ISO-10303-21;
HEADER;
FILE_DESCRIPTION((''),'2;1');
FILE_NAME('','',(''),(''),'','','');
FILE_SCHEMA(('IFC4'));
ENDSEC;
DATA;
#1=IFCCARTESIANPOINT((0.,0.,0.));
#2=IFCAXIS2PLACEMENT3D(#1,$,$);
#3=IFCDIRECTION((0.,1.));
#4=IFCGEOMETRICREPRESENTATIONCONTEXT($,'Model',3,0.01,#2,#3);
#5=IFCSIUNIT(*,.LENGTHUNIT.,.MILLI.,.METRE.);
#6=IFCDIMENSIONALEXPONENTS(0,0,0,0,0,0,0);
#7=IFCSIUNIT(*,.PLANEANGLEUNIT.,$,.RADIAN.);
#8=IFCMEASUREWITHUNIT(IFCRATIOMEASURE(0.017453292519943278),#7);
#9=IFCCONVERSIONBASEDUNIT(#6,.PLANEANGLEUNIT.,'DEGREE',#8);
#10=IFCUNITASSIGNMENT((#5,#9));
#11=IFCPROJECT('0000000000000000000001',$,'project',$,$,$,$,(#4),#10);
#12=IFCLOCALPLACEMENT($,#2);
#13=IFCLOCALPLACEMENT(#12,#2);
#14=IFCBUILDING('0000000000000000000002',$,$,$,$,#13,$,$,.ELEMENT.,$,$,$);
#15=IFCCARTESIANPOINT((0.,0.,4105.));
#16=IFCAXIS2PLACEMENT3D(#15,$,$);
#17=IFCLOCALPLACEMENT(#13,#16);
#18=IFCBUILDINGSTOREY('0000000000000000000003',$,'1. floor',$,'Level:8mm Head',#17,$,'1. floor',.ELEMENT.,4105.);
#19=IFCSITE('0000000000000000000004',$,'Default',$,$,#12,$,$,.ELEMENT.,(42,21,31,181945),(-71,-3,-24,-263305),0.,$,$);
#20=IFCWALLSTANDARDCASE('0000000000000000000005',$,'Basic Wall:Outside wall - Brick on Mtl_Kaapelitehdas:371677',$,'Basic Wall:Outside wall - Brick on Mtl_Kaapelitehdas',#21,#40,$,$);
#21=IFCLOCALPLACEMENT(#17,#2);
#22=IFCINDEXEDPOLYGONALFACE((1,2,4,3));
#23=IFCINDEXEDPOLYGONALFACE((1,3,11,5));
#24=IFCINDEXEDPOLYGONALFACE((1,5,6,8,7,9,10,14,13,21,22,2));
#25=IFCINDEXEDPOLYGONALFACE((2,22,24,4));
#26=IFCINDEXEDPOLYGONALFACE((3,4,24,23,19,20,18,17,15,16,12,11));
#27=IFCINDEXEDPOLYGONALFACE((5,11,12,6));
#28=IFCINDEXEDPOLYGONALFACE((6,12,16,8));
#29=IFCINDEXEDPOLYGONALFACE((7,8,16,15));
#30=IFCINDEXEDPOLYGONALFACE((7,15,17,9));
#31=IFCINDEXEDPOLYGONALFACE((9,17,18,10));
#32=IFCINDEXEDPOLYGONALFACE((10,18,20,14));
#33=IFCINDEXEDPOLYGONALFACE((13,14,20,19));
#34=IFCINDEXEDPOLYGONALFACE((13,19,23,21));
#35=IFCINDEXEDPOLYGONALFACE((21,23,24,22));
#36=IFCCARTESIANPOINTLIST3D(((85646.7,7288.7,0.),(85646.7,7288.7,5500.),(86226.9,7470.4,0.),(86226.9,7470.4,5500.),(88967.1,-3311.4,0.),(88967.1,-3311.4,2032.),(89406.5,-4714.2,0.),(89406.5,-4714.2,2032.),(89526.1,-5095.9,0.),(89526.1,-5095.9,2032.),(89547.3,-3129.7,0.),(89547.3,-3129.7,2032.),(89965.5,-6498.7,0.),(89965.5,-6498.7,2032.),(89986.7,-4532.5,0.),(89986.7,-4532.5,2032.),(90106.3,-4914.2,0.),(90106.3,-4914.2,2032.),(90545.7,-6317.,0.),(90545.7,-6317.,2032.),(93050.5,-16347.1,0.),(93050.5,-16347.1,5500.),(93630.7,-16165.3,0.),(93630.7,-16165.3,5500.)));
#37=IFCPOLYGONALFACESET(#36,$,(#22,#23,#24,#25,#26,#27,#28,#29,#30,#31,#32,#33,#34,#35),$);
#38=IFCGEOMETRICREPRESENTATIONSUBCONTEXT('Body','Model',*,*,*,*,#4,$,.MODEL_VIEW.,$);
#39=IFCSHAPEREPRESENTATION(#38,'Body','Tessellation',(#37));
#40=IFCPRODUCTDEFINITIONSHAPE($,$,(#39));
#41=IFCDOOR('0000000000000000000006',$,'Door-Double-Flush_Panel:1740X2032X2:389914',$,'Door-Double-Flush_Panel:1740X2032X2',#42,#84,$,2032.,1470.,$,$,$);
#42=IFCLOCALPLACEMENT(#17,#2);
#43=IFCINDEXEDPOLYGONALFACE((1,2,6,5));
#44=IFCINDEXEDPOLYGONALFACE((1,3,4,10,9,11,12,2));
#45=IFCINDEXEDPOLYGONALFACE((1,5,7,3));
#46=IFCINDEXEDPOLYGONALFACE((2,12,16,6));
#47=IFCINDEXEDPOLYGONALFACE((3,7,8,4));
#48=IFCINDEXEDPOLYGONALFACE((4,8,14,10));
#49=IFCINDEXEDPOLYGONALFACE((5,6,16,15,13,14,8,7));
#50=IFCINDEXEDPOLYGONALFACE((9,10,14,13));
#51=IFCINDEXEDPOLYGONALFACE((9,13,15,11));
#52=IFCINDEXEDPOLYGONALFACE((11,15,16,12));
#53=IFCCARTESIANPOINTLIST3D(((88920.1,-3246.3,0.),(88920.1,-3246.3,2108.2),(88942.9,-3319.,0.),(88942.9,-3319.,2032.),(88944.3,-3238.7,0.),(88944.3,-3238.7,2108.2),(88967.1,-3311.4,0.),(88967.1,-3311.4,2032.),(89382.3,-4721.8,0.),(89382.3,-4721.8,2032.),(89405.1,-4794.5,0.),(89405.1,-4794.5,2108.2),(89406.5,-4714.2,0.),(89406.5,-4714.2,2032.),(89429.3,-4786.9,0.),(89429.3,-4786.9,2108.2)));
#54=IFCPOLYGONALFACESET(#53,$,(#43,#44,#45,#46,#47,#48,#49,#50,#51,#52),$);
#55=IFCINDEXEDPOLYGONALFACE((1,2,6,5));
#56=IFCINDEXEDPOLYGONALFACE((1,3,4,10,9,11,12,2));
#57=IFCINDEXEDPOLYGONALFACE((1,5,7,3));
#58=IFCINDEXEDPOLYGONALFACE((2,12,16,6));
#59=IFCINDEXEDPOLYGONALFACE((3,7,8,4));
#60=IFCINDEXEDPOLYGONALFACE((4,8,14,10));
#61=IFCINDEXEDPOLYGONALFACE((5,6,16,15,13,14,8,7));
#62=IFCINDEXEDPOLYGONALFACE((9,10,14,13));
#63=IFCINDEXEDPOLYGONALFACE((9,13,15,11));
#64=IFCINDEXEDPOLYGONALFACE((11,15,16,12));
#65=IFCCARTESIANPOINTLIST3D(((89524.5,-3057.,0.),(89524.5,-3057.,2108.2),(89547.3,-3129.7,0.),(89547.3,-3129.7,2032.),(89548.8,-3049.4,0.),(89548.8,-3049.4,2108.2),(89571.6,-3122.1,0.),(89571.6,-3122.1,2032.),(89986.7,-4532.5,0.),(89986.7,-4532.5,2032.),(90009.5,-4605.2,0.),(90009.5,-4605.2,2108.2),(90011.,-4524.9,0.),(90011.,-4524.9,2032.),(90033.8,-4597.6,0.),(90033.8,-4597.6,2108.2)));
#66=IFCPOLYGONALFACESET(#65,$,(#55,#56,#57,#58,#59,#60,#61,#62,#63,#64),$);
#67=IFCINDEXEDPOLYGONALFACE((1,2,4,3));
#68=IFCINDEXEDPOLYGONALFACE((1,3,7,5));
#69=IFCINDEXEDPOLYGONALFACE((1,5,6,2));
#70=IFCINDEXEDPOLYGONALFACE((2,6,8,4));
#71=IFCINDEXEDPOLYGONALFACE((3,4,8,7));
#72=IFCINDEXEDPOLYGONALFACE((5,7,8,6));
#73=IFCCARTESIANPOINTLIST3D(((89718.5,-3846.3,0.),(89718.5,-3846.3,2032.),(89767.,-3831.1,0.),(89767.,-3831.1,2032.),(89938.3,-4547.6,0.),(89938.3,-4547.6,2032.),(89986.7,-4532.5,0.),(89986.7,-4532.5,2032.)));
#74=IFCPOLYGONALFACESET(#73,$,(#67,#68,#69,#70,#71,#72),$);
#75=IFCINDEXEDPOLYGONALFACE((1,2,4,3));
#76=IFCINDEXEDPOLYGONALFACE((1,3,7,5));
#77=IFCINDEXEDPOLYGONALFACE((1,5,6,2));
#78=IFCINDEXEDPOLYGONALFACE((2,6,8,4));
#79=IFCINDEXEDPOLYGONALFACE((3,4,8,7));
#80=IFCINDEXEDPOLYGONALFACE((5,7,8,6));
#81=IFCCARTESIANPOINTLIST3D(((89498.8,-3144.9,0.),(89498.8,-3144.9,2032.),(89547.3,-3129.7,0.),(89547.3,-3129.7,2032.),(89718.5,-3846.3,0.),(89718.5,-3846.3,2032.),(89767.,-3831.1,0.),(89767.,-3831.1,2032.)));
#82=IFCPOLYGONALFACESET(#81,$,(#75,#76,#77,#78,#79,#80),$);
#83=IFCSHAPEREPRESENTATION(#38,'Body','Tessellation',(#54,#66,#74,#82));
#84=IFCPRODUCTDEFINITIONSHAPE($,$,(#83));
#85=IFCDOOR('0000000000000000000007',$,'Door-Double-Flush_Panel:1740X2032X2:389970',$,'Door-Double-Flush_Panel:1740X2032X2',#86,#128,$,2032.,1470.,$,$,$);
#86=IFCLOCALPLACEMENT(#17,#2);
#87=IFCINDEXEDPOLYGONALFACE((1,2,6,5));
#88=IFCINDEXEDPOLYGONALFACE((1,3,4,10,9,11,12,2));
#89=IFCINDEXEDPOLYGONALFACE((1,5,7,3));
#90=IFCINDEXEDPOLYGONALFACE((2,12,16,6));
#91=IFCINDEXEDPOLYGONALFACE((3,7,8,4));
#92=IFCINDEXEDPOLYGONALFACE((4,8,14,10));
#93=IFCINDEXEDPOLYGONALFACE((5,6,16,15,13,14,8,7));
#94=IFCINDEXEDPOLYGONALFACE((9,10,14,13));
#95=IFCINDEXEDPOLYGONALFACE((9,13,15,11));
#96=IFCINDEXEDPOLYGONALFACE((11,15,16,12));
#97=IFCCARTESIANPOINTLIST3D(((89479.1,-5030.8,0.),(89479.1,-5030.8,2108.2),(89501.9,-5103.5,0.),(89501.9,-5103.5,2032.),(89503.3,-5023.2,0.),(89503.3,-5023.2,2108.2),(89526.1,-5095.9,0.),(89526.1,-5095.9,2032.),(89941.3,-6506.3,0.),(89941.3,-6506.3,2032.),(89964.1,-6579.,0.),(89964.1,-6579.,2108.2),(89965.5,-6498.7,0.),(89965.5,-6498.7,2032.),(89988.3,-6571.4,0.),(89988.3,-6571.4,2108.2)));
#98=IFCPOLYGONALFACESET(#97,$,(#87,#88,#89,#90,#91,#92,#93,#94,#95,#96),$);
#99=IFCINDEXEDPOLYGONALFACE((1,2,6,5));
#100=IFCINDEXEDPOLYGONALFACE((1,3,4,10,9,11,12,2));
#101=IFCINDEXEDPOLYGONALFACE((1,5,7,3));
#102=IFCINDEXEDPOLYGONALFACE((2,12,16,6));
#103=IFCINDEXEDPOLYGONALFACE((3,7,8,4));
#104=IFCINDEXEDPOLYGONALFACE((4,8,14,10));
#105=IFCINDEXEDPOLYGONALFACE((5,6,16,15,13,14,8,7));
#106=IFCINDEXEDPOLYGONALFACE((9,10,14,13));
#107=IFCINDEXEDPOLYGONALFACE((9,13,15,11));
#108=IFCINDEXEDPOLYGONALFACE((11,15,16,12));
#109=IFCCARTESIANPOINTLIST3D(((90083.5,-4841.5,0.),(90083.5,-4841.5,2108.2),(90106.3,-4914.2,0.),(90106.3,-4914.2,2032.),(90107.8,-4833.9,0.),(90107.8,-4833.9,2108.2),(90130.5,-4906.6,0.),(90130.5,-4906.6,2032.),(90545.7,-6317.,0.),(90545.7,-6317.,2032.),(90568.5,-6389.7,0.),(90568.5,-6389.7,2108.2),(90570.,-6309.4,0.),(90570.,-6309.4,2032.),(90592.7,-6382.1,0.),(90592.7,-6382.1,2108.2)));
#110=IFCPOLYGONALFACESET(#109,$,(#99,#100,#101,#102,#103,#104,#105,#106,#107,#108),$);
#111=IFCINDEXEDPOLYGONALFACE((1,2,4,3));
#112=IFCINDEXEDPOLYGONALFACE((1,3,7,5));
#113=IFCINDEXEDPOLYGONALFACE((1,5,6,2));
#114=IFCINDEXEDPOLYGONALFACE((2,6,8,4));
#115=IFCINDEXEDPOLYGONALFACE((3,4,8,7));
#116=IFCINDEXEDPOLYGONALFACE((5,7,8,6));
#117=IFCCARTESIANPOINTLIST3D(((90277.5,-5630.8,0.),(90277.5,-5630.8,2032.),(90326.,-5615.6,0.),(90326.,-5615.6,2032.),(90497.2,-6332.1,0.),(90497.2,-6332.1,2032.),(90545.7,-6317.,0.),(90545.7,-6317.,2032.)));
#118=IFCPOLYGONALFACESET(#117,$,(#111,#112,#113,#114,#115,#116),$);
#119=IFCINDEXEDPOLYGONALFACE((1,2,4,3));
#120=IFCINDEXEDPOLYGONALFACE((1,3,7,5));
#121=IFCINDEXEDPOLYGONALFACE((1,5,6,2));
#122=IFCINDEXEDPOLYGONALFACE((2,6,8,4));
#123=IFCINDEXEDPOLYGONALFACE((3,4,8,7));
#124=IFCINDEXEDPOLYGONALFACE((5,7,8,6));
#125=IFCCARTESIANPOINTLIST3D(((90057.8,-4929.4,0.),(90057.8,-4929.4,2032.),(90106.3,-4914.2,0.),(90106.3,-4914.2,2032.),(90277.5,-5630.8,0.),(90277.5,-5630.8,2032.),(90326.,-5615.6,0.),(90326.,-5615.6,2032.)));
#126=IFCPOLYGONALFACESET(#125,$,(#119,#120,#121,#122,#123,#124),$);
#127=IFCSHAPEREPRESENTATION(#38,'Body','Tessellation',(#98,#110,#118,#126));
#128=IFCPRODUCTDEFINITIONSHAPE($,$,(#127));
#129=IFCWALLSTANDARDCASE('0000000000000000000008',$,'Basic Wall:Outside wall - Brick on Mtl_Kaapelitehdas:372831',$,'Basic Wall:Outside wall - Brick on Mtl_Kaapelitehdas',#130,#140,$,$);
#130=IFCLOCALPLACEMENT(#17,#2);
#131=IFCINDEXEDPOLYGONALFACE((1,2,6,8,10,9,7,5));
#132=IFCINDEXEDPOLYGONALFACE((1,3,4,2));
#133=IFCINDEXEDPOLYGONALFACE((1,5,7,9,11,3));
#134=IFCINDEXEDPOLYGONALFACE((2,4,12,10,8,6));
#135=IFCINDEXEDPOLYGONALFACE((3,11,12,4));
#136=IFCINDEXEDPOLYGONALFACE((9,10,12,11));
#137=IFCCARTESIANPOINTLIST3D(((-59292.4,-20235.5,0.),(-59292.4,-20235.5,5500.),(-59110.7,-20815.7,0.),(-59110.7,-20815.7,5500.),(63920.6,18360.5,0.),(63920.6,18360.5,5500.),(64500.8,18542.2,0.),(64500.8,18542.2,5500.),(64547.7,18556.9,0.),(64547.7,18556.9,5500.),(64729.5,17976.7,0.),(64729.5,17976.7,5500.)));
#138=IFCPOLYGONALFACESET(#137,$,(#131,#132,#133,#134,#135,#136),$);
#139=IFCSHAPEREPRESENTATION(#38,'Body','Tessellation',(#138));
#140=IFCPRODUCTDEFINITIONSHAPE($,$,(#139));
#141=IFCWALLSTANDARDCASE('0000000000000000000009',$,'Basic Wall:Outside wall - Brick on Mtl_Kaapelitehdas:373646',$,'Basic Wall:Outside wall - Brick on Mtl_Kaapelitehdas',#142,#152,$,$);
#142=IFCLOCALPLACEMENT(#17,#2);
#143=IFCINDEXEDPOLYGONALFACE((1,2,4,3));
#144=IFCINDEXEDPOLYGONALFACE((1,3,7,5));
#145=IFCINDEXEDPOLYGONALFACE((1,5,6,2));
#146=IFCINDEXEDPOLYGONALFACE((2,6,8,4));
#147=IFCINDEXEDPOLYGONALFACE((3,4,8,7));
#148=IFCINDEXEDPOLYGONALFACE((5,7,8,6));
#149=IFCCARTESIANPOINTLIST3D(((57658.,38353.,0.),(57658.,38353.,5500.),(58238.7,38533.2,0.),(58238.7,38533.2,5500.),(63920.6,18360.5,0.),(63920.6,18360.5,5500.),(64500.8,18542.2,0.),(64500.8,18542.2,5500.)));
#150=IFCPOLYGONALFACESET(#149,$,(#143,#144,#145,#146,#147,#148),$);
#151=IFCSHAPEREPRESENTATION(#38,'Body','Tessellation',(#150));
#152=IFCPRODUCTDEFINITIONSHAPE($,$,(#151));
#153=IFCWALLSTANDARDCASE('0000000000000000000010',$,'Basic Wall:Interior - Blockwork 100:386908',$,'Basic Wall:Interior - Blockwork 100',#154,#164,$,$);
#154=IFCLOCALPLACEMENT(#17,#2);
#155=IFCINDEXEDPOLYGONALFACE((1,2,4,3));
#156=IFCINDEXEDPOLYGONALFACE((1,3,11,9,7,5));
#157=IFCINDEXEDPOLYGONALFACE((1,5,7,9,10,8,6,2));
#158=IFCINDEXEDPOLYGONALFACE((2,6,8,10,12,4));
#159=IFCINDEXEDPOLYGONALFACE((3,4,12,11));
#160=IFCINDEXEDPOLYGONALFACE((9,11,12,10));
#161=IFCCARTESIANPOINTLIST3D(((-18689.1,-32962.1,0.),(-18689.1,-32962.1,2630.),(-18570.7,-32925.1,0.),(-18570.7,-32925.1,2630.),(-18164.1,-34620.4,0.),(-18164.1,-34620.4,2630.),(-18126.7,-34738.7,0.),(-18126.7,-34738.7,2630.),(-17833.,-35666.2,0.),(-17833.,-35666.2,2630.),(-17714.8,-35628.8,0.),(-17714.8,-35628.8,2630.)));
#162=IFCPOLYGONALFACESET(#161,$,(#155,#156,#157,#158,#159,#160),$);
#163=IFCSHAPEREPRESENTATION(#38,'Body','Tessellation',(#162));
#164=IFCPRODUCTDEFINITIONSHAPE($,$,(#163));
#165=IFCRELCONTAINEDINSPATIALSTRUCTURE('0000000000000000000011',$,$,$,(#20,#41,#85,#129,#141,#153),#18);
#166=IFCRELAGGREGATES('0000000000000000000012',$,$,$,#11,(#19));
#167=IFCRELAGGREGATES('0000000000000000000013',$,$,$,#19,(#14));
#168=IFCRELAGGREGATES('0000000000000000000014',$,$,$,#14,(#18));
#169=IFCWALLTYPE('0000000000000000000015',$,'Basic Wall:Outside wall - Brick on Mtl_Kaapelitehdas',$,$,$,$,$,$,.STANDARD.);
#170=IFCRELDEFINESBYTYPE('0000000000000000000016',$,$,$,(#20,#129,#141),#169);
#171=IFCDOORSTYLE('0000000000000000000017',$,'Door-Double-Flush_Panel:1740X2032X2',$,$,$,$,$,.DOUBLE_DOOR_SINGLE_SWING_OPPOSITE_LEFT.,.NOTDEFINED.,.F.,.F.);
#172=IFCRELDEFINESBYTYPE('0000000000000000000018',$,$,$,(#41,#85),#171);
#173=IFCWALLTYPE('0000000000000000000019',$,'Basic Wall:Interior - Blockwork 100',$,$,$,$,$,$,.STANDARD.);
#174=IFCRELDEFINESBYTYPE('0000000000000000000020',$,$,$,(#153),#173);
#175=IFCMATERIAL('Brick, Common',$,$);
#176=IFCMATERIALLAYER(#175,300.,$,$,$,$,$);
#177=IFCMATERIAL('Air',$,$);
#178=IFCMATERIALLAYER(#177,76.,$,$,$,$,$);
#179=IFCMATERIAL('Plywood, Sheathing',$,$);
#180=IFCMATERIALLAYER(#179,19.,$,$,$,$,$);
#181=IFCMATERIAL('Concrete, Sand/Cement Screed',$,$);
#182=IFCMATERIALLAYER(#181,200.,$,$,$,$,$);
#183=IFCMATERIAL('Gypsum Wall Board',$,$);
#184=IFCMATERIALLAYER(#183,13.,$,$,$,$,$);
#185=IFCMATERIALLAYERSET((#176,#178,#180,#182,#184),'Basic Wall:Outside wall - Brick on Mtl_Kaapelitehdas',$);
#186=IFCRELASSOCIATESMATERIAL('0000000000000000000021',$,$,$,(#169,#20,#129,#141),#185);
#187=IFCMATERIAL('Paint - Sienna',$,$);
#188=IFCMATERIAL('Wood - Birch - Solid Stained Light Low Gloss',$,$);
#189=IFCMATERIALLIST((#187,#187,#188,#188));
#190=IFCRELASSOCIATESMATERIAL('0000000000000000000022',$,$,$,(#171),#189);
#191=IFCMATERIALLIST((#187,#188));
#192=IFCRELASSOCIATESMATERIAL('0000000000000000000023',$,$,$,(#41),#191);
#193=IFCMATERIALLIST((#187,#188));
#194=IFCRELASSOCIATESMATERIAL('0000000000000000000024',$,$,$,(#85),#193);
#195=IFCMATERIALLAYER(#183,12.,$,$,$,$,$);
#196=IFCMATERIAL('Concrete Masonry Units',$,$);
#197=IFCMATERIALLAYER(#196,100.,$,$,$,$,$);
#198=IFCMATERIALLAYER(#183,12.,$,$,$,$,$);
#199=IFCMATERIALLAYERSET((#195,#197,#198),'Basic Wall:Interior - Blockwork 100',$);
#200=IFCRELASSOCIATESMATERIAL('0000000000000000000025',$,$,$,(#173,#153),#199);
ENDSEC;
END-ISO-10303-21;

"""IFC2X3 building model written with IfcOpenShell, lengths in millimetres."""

from ifc_helpers import new_model, entity, si_unit, converted_unit, direction, frame, frame_2d, origin, origin_2d_with_axis, place, context, subcontext, project, spatial, polyline, rectangle, outline, extrude, source, transform, mapped, material, material_list, layer, layer_set, layer_usage, type_object, type_shapes, element, fill, save


model = new_model("IFC2X3")

# Units and contexts
model_context = context("Model", 3, precision=0.01, world=origin(), true_north=direction((0.0, 1.0)))
body_context = subcontext(model_context, "Body", "Model", "MODEL_VIEW")
ifc_project = project(units=[si_unit("LENGTHUNIT", "METRE", prefix="MILLI"), converted_unit("PLANEANGLEUNIT", "DEGREE", entity("IfcRatioMeasure", 0.017453292519943278), si_unit("PLANEANGLEUNIT", "RADIAN"), dimensions=[0, 0, 0, 0, 0, 0, 0])], contexts=[model_context])

# Site, building, storey
site_placement = place(None, origin())
site = spatial("IfcSite", under=ifc_project, at=site_placement, Name="Default", CompositionType="ELEMENT", RefLatitude=(42, 21, 31, 181945), RefLongitude=(-71, -3, -24, -263305), RefElevation=0.0)
building_placement = place(site_placement, origin())
building = spatial("IfcBuilding", under=site, at=building_placement, CompositionType="ELEMENT")
storey_placement = place(building_placement, frame((0.0, 0.0, 4105.0)))
storey = spatial("IfcBuildingStorey", under=building, at=storey_placement, Name="1. floor", ObjectType="Level:8mm Head", LongName="1. floor", CompositionType="ELEMENT", Elevation=4105.0)

# Wall, openings, doors
ifc_material_1 = material(Name="Brick, Common")
ifc_layer_1 = layer(ifc_material_1, 300.0)
ifc_material_2 = material(Name="Air")
ifc_layer_2 = layer(ifc_material_2, 76.0)
ifc_material_3 = material(Name="Plywood, Sheathing")
ifc_layer_3 = layer(ifc_material_3, 19.0)
ifc_material_4 = material(Name="Concrete, Sand/Cement Screed")
ifc_layer_4 = layer(ifc_material_4, 200.0)
ifc_material_5 = material(Name="Gypsum Wall Board")
ifc_layer_5 = layer(ifc_material_5, 13.0)
ifc_layer_set_1 = layer_set([ifc_layer_1, ifc_layer_2, ifc_layer_3, ifc_layer_4, ifc_layer_5], Name="Basic Wall:Outside wall - Brick on Mtl_Kaapelitehdas")
wall_type_1 = type_object("IfcWallType", Name="Basic Wall:Outside wall - Brick on Mtl_Kaapelitehdas", PredefinedType="STANDARD", material=ifc_layer_set_1)
ifc_material_6 = material(Name="Paint - Sienna")
ifc_material_7 = material(Name="Wood - Birch - Solid Stained Light Low Gloss")
ifc_material_list_1 = material_list([ifc_material_6, ifc_material_6, ifc_material_7, ifc_material_7])
door_style_1 = type_object("IfcDoorStyle", Name="Door-Double-Flush_Panel:1740X2032X2", ConstructionType="NOTDEFINED", OperationType="DOUBLE_DOOR_SINGLE_SWING_OPPOSITE_LEFT", ParameterTakesPrecedence=False, Sizeable=False, material=ifc_material_list_1)
shared_shape_1 = source(origin(), body_context, "Body", "SweptSolid", [
    extrude(outline(polyline([(-996.9, 735.0), (1035.0, 735.0), (1035.0, 811.2), (-1073.1, 811.2), (-1073.1, -811.2), (1035.0, -811.2), (1035.0, -735.0), (-996.9, -735.0), (-996.9, 735.0)])), frame((735.0, -25.4, 1035.0), z_axis=(0.0, 1.0, 0.0), x_axis=(0.0, 0.0, -1.0)), (0.0, 0.0, 1.0), 25.4),
    extrude(outline(polyline([(-996.9, 735.0), (1035.0, 735.0), (1035.0, 811.2), (-1073.1, 811.2), (-1073.1, -811.2), (1035.0, -811.2), (1035.0, -735.0), (-996.9, -735.0), (-996.9, 735.0)])), frame((735.0, 608.0, 1035.0), z_axis=(0.0, 1.0, 0.0), x_axis=(0.0, 0.0, -1.0)), (0.0, 0.0, 1.0), 25.4),
    extrude(rectangle(XDim=50.8, YDim=735.0, at=origin_2d_with_axis()), frame((1102.5, 582.6, 0.0), z_axis=(0.0, 0.0, 1.0), x_axis=(0.0, -1.0, 0.0)), (0.0, 0.0, 1.0), 2032.0),
    extrude(rectangle(XDim=50.8, YDim=735.0, at=frame_2d((0.0, 0.0), x_axis=(1.0, 0.0))), frame((367.5, 582.6, 0.0), z_axis=(0.0, 0.0, 1.0), x_axis=(0.0, -1.0, 0.0)), (0.0, 0.0, 1.0), 2032.0),
])
type_shapes(door_style_1, [shared_shape_1])
ifc_layer_usage_1 = layer_usage(ifc_layer_set_1, "AXIS2", "NEGATIVE", 304.0)
wall_1_placement = place(storey_placement, frame((85936.8, 7379.6, 0.0), z_axis=(0.0, 0.0, 1.0), x_axis=(0.298924, -0.954277, 0.0)))
wall_1 = element("IfcWallStandardCase", 1, at=wall_1_placement, inside=storey, type_object=wall_type_1, material=ifc_layer_usage_1, Name="Basic Wall:Outside wall - Brick on Mtl_Kaapelitehdas:371677", ObjectType="Basic Wall:Outside wall - Brick on Mtl_Kaapelitehdas", context=body_context, shape_type="SweptSolid", body=[
    extrude(rectangle(XDim=24768.2, YDim=608.0, at=frame_2d((12384.1, 0.0), x_axis=(-1.0, 0.0))), origin(), (0.0, 0.0, 1.0), 5500.0),
])
opening_1_placement = place(wall_1_placement, frame((11108.0, -304.0, 0.0)))
opening_1 = element("IfcOpeningElement", 2, at=opening_1_placement, cuts=wall_1, ObjectType="Opening", context=body_context, shape_type="SweptSolid", body=[
    extrude(rectangle(XDim=2032.0, YDim=1470.0, at=frame_2d((1016.0, 735.0), x_axis=(1.0, 0.0))), frame((0.0, 0.0, 0.0), z_axis=(0.0, 1.0, 0.0), x_axis=(0.0, 0.0, 1.0)), (0.0, 0.0, 1.0), 608.0),
])
opening_2_placement = place(wall_1_placement, frame((12978.0, -304.0, 0.0)))
opening_2 = element("IfcOpeningElement", 3, at=opening_2_placement, cuts=wall_1, ObjectType="Opening", context=body_context, shape_type="SweptSolid", body=[
    extrude(rectangle(XDim=2032.0, YDim=1470.0, at=frame_2d((1016.0, 735.0), x_axis=(1.0, 0.0))), frame((0.0, 0.0, 0.0), z_axis=(0.0, 1.0, 0.0), x_axis=(0.0, 0.0, 1.0)), (0.0, 0.0, 1.0), 608.0),
])
ifc_material_list_2 = material_list([ifc_material_6, ifc_material_7])
door_1_placement = place(opening_1_placement, origin())
door_1 = element("IfcDoor", 4, at=door_1_placement, inside=storey, type_object=door_style_1, material=ifc_material_list_2, Name="Door-Double-Flush_Panel:1740X2032X2:389914", ObjectType="Door-Double-Flush_Panel:1740X2032X2", OverallHeight=2032.0, OverallWidth=1470.0, context=body_context, shape_type="MappedRepresentation", body=[
    mapped(shared_shape_1, transform((0.0, 0.0, 0.0), scale=1.0)),
])
fill(opening_1, door_1)
ifc_material_list_3 = material_list([ifc_material_6, ifc_material_7])
door_2_placement = place(opening_2_placement, origin())
door_2 = element("IfcDoor", 5, at=door_2_placement, inside=storey, type_object=door_style_1, material=ifc_material_list_3, Name="Door-Double-Flush_Panel:1740X2032X2:389970", ObjectType="Door-Double-Flush_Panel:1740X2032X2", OverallHeight=2032.0, OverallWidth=1470.0, context=body_context, shape_type="MappedRepresentation", body=[
    mapped(shared_shape_1, transform((0.0, 0.0, 0.0), scale=1.0)),
])
fill(opening_2, door_2)

# Walls
ifc_layer_usage_2 = layer_usage(ifc_layer_set_1, "AXIS2", "NEGATIVE", 304.0)
wall_2_placement = place(storey_placement, frame((64638.6, 18266.8, 0.0), z_axis=(0.0, 0.0, 1.0), x_axis=(-0.954277, -0.298924, 0.0)))
element("IfcWallStandardCase", 6, at=wall_2_placement, inside=storey, type_object=wall_type_1, material=ifc_layer_usage_2, Name="Basic Wall:Outside wall - Brick on Mtl_Kaapelitehdas:372831", ObjectType="Basic Wall:Outside wall - Brick on Mtl_Kaapelitehdas", context=body_context, shape_type="SweptSolid", body=[
    extrude(outline(polyline([(129773.8, -304.0), (129773.9, 304.0), (0.0, 304.0), (0.0, -304.0), (49.2, -304.0), (657.2, -304.0), (129773.8, -304.0)])), origin(), (0.0, 0.0, 1.0), 5500.0),
])
ifc_layer_usage_3 = layer_usage(ifc_layer_set_1, "AXIS2", "NEGATIVE", 304.0)
wall_3_placement = place(storey_placement, frame((57948.1, 38443.9, 0.0), z_axis=(0.0, 0.0, 1.0), x_axis=(0.298924, -0.954277, 0.0)))
element("IfcWallStandardCase", 7, at=wall_3_placement, inside=storey, type_object=wall_type_1, material=ifc_layer_usage_3, Name="Basic Wall:Outside wall - Brick on Mtl_Kaapelitehdas:373646", ObjectType="Basic Wall:Outside wall - Brick on Mtl_Kaapelitehdas", context=body_context, shape_type="SweptSolid", body=[
    extrude(outline(polyline([(20950.4, -304.0), (20950.4, 304.0), (1.6, 304.0), (0.0, -304.0), (20950.4, -304.0)])), origin(), (0.0, 0.0, 1.0), 5500.0),
])
ifc_layer_6 = layer(ifc_material_5, 12.0)
ifc_material_8 = material(Name="Concrete Masonry Units")
ifc_layer_7 = layer(ifc_material_8, 100.0)
ifc_layer_8 = layer(ifc_material_5, 12.0)
ifc_layer_set_2 = layer_set([ifc_layer_6, ifc_layer_7, ifc_layer_8], Name="Basic Wall:Interior - Blockwork 100")
ifc_layer_usage_4 = layer_usage(ifc_layer_set_2, "AXIS2", "NEGATIVE", 62.0)
wall_type_2 = type_object("IfcWallType", Name="Basic Wall:Interior - Blockwork 100", PredefinedType="STANDARD", material=ifc_layer_set_2)
wall_4_placement = place(storey_placement, frame((-17773.9, -35647.5, 0.0), z_axis=(0.0, 0.0, 1.0), x_axis=(-0.301797, 0.953372, 0.0)))
element("IfcWallStandardCase", 8, at=wall_4_placement, inside=storey, type_object=wall_type_2, material=ifc_layer_usage_4, Name="Basic Wall:Interior - Blockwork 100:386908", ObjectType="Basic Wall:Interior - Blockwork 100", context=body_context, shape_type="SweptSolid", body=[
    extrude(outline(polyline([(2836.0, -62.0), (2836.4, 62.0), (1096.9, 62.0), (972.9, 62.0), (0.0, 62.0), (0.0, -62.0), (2836.0, -62.0)])), origin(), (0.0, 0.0, 1.0), 2630.0),
])

save(model, "model.ifc")
